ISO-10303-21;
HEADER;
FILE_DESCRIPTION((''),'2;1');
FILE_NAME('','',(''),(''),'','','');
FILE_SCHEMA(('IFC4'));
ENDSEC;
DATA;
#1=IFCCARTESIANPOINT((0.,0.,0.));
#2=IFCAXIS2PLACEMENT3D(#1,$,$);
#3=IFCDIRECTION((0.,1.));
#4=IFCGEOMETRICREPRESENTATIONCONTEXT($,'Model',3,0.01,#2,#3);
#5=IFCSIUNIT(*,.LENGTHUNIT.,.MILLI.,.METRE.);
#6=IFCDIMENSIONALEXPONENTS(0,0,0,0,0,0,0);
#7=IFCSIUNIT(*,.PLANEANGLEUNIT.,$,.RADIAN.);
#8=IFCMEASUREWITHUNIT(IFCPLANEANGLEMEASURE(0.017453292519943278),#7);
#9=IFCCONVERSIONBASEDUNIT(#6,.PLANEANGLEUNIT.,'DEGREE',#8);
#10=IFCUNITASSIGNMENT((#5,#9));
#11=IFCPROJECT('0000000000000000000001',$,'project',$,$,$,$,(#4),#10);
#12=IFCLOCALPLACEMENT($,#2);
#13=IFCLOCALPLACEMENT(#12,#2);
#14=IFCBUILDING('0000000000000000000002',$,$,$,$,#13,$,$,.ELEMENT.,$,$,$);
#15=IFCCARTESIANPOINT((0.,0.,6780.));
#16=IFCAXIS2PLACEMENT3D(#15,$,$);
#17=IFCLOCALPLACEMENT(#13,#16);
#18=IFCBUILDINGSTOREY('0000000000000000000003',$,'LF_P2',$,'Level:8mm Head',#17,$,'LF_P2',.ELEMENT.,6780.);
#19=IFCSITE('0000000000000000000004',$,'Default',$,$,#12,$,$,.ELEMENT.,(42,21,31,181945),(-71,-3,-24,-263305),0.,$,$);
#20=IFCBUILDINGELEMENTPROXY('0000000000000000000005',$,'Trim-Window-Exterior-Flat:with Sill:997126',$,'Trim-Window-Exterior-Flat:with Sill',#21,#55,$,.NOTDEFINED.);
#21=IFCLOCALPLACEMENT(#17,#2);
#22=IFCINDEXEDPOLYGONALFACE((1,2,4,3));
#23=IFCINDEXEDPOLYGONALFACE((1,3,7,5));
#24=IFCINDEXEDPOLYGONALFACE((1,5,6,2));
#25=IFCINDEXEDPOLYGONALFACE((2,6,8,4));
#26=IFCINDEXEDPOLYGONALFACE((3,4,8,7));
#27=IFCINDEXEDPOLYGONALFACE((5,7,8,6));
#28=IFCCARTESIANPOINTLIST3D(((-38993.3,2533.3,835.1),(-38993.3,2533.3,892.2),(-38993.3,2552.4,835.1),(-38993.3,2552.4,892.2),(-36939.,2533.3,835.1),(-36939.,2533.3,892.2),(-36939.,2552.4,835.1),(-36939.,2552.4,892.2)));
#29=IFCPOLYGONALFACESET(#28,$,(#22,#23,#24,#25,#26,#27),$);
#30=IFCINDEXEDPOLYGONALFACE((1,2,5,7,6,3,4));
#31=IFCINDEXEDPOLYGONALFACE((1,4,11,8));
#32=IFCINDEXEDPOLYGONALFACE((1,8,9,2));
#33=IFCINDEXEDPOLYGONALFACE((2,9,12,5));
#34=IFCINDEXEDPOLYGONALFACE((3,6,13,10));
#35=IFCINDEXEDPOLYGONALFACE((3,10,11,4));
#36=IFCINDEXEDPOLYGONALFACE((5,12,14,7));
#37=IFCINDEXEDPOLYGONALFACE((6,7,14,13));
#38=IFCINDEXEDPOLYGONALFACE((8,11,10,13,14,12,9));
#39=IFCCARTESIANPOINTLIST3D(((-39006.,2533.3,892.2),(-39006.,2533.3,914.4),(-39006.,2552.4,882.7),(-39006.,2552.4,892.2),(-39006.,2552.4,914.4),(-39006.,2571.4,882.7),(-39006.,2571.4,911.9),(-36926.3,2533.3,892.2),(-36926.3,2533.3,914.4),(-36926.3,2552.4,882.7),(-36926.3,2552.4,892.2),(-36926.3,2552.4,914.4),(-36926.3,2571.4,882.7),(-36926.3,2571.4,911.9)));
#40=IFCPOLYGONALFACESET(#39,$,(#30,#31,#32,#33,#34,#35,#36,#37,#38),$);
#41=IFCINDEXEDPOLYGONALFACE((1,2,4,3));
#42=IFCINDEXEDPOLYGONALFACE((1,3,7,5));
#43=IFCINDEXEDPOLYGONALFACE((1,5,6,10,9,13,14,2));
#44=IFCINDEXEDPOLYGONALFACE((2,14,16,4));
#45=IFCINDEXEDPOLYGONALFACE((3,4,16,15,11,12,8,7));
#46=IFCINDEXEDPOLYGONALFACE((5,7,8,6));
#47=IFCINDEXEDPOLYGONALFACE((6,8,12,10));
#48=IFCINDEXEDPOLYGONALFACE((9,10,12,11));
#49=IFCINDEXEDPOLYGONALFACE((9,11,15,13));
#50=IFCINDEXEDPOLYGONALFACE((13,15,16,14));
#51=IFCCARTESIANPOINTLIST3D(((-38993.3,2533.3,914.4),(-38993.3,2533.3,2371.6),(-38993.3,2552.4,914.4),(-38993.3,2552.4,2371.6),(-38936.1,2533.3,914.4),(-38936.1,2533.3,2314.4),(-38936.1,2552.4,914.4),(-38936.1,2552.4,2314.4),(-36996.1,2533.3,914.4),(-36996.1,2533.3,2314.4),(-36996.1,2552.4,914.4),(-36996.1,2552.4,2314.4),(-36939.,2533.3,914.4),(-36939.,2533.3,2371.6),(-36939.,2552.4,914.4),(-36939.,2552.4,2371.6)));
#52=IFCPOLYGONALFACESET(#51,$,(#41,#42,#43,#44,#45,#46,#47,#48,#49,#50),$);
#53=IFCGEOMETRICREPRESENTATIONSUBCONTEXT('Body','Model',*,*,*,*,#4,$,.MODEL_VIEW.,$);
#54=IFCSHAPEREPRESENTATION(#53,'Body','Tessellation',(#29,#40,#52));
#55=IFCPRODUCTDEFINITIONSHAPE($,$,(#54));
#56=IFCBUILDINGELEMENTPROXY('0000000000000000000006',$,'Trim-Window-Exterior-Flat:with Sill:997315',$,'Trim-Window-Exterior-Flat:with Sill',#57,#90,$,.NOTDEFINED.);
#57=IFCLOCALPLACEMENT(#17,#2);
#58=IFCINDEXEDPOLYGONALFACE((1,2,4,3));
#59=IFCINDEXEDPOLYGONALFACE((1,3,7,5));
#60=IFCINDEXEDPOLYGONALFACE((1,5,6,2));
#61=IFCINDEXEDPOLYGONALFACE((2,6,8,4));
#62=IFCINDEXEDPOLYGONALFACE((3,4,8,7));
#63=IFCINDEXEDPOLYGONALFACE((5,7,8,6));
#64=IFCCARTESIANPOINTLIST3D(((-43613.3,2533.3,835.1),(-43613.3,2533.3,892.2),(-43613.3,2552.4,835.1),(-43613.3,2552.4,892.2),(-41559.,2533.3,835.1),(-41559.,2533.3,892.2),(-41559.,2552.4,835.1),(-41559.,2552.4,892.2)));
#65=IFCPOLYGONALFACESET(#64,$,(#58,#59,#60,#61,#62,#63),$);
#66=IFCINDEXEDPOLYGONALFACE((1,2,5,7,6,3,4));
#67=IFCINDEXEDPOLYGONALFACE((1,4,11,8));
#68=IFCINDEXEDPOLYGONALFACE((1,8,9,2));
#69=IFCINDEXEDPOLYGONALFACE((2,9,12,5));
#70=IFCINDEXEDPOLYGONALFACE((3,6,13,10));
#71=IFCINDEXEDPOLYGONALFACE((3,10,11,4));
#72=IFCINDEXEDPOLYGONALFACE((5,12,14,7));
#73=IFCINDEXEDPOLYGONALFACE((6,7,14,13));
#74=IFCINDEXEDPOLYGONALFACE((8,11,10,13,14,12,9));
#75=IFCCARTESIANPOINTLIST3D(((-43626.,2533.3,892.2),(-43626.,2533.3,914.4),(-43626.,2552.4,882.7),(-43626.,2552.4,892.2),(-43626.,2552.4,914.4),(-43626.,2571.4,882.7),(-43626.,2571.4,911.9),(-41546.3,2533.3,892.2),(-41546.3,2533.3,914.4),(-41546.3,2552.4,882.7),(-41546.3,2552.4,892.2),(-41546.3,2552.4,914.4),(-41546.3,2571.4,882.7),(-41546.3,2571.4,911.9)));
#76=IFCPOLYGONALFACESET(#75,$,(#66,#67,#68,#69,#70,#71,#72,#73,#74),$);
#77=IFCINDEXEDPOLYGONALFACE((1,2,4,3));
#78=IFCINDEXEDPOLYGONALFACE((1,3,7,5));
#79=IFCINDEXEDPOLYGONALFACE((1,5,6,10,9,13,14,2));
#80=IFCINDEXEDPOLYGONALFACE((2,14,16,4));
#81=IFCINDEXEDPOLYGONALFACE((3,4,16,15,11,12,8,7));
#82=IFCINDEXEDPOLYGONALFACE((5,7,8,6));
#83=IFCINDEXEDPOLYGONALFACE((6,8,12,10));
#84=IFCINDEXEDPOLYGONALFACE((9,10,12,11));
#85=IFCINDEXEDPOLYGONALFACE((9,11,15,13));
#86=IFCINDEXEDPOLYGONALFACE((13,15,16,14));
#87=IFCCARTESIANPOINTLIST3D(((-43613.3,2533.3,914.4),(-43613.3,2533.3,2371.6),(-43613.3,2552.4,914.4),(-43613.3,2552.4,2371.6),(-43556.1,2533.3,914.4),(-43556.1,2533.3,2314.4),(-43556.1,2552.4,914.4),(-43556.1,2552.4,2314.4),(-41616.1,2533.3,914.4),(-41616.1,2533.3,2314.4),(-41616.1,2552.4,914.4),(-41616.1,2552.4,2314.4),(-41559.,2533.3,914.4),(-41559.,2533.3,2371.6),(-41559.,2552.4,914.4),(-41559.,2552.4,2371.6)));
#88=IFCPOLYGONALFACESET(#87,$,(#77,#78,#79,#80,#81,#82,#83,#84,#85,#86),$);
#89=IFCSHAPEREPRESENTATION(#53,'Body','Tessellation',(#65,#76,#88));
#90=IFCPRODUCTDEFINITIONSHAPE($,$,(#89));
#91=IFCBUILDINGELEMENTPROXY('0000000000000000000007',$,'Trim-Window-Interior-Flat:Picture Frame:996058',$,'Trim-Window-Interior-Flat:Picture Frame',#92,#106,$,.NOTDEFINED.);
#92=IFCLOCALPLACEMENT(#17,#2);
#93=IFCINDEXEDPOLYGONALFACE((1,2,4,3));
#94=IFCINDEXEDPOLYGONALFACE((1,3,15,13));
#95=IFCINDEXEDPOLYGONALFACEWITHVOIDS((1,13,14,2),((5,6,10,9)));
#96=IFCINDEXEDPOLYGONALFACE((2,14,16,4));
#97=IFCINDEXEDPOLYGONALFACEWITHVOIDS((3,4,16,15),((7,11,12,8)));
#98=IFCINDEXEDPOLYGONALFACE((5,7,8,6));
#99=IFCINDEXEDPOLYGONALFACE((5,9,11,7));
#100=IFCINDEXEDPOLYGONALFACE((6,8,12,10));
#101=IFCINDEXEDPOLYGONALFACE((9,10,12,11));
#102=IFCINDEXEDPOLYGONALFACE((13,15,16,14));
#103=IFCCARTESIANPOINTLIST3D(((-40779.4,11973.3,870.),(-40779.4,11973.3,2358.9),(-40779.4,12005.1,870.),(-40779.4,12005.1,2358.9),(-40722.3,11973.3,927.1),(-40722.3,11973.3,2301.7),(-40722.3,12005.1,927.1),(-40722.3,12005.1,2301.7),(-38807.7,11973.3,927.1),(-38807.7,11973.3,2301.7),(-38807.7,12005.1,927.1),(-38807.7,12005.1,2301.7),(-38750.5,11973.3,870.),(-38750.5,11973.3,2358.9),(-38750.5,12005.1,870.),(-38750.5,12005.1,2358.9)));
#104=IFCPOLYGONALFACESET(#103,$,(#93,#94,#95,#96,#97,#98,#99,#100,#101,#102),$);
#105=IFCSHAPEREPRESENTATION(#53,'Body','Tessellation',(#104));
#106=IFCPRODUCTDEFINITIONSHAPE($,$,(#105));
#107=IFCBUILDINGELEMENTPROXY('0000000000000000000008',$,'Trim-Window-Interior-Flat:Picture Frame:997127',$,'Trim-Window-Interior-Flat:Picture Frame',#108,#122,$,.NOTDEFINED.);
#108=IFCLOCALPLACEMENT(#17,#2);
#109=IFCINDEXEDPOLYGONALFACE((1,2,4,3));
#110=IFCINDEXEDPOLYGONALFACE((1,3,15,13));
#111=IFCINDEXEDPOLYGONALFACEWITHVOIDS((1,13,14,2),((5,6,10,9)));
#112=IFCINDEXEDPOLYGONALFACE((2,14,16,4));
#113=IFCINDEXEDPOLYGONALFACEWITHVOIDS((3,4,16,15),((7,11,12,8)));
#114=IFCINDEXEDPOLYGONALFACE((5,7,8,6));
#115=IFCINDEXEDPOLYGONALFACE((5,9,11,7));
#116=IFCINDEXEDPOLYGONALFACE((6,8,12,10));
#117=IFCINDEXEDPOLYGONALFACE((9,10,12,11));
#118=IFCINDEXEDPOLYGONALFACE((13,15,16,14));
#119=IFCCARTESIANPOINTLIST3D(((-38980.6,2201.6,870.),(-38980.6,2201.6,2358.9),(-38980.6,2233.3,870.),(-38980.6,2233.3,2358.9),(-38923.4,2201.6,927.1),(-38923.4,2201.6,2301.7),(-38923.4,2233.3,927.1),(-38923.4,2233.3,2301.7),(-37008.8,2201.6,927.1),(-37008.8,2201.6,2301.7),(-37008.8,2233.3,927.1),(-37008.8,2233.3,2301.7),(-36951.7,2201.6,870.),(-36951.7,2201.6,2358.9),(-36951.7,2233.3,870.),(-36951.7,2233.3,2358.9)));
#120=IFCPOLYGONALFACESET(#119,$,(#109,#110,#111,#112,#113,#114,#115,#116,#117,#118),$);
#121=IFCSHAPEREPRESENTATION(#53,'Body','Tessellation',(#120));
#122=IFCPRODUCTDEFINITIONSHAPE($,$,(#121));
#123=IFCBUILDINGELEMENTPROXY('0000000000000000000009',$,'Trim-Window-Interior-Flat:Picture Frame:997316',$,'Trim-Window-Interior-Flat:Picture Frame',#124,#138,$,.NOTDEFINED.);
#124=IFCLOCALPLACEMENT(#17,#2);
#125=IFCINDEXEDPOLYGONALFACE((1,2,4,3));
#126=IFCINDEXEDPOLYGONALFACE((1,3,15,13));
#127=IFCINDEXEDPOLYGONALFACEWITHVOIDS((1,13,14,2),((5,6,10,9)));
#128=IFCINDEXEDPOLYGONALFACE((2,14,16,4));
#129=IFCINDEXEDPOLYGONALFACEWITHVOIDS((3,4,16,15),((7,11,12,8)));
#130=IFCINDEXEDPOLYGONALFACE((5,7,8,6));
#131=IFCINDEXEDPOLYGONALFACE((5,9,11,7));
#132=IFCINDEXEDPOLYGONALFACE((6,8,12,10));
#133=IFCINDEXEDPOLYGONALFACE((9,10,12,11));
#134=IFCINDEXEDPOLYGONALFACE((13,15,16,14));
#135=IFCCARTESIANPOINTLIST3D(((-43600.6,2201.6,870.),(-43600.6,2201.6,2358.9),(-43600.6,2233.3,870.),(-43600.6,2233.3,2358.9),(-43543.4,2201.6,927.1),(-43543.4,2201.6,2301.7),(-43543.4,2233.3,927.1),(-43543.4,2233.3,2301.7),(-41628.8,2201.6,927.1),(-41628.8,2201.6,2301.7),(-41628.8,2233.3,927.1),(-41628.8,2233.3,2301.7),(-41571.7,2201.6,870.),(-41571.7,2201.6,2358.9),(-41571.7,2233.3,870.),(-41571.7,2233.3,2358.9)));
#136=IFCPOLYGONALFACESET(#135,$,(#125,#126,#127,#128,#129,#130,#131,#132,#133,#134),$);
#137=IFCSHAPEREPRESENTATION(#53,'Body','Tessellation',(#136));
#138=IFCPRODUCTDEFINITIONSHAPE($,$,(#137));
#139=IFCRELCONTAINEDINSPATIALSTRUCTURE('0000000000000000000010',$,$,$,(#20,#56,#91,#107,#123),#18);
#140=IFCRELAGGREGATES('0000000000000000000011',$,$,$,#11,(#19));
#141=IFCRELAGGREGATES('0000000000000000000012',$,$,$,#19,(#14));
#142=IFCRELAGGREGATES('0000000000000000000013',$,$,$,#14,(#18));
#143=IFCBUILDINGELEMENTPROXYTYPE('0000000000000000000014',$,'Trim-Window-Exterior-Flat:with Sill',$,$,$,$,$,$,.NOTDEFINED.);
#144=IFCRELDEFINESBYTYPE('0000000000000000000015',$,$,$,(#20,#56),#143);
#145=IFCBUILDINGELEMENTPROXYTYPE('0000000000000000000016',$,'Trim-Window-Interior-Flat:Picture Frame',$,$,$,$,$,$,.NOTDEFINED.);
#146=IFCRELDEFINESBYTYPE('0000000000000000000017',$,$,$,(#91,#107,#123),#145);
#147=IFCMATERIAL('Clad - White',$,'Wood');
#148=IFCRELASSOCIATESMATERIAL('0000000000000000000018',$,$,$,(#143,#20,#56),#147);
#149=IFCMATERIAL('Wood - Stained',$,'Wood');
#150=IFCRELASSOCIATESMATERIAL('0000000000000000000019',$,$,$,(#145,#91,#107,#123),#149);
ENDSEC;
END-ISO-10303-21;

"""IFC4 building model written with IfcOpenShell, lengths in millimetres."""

from ifc_helpers import new_model, entity, si_unit, converted_unit, direction, frame, origin, place, context, subcontext, project, spatial, indexed_curve, outline, extrude, source, transform, mapped, material, type_object, type_shapes, element, save


model = new_model("IFC4")

# Units and contexts
model_context = context("Model", 3, precision=0.01, world=origin(), true_north=direction((0.0, 1.0)))
body_context = subcontext(model_context, "Body", "Model", "MODEL_VIEW")
ifc_project = project(units=[si_unit("LENGTHUNIT", "METRE", prefix="MILLI"), converted_unit("PLANEANGLEUNIT", "DEGREE", entity("IfcPlaneAngleMeasure", 0.017453292519943278), si_unit("PLANEANGLEUNIT", "RADIAN"), dimensions=[0, 0, 0, 0, 0, 0, 0])], contexts=[model_context])

# Site, building, storey
site_placement = place(None, origin())
site = spatial("IfcSite", under=ifc_project, at=site_placement, Name="Default", CompositionType="ELEMENT", RefLatitude=(42, 21, 31, 181945), RefLongitude=(-71, -3, -24, -263305), RefElevation=0.0)
building_placement = place(site_placement, origin())
building = spatial("IfcBuilding", under=site, at=building_placement, CompositionType="ELEMENT")
storey_placement = place(building_placement, frame((0.0, 0.0, 6780.0)))
storey = spatial("IfcBuildingStorey", under=building, at=storey_placement, Name="LF_P2", ObjectType="Level:8mm Head", LongName="LF_P2", CompositionType="ELEMENT", Elevation=6780.0)

# Building element proxies
ifc_material_1 = material(Name="Clad - White", Category="Wood")
ifc_material_2 = material(Name="Wood - Stained", Category="Wood")
building_element_proxy_type_1 = type_object("IfcBuildingElementProxyType", Name="Trim-Window-Exterior-Flat:with Sill", PredefinedType="NOTDEFINED", material=ifc_material_1)
shared_shape_1 = source(origin(), body_context, "Body", "SweptSolid", [
    extrude(outline(indexed_curve([(-1027.1, -28.6), (1027.1, -28.6), (1027.1, 28.6), (-1027.1, 28.6), (-1027.1, -28.6)], self_intersect=False)), frame((0.0, -1450.8, 0.0), z_axis=(0.0, 0.0, 1.0), x_axis=(-1.0, 0.0, 0.0)), (0.0, 0.0, 1.0), 19.0),
    extrude(outline(indexed_curve([(-19.0, -16.0), (0.0, -16.0), (0.0, -6.4), (19.0, -6.4), (19.0, 15.8), (0.0, 15.8), (-19.0, 13.3), (-19.0, -16.0)], self_intersect=False)), frame((-1039.8, -1415.8, 19.0), z_axis=(1.0, 0.0, 0.0), x_axis=(0.0, 0.0, -1.0)), (0.0, 0.0, 1.0), 2079.7),
    extrude(outline(indexed_curve([(-742.9, -1027.1), (714.3, -1027.1), (714.3, -970.0), (-685.7, -970.0), (-685.7, 970.0), (714.3, 970.0), (714.3, 1027.1), (-742.9, 1027.1), (-742.9, -1027.1)], self_intersect=False)), frame((0.0, -685.7, 0.0), z_axis=(0.0, 0.0, 1.0), x_axis=(0.0, -1.0, 0.0)), (0.0, 0.0, 1.0), 19.0),
])
type_shapes(building_element_proxy_type_1, [shared_shape_1])
for number, where, z_axis, x_axis, name in (
    (1, (-37966.1, 2533.3, 2314.4), (0.0, 1.0, 0.0), (-1.0, 0.0, 0.0), "Trim-Window-Exterior-Flat:with Sill:997126"),
    (2, (-42586.1, 2533.3, 2314.4), (0.0, 1.0, 0.0), (-1.0, 0.0, 0.0), "Trim-Window-Exterior-Flat:with Sill:997315"),
):
    element("IfcBuildingElementProxy", number, at=place(storey_placement, frame(where, z_axis=z_axis, x_axis=x_axis)), inside=storey, type_object=building_element_proxy_type_1, material=ifc_material_1, Name=name, ObjectType="Trim-Window-Exterior-Flat:with Sill", PredefinedType="NOTDEFINED", context=body_context, shape_type="MappedRepresentation", body=[
        mapped(shared_shape_1, transform((0.0, 0.0, 0.0), scale=1.0)),
    ])
building_element_proxy_type_2 = type_object("IfcBuildingElementProxyType", Name="Trim-Window-Interior-Flat:Picture Frame", PredefinedType="NOTDEFINED", material=ifc_material_2)
shared_shape_2 = source(origin(), body_context, "Body", "SweptSolid", [
    extrude(outline(indexed_curve([(-1014.4, -744.4), (1014.4, -744.4), (1014.4, 744.4), (-1014.4, 744.4), (-1014.4, -744.4)], self_intersect=False), holes=[indexed_curve([(-957.3, -687.3), (-957.3, 687.3), (957.3, 687.3), (957.3, -687.3), (-957.3, -687.3)], self_intersect=False)]), frame((0.0, -700.0, 0.0), z_axis=(0.0, 0.0, 1.0), x_axis=(-1.0, 0.0, 0.0)), (0.0, 0.0, 1.0), 31.7),
])
type_shapes(building_element_proxy_type_2, [shared_shape_2])
for number, where, z_axis, x_axis, name in (
    (3, (-39765.0, 11973.3, 2314.4), (0.0, 1.0, 0.0), (-1.0, 0.0, 0.0), "Trim-Window-Interior-Flat:Picture Frame:996058"),
    (4, (-37966.1, 2233.3, 2314.4), (0.0, -1.0, 0.0), (1.0, 0.0, 0.0), "Trim-Window-Interior-Flat:Picture Frame:997127"),
    (5, (-42586.1, 2233.3, 2314.4), (0.0, -1.0, 0.0), (1.0, 0.0, 0.0), "Trim-Window-Interior-Flat:Picture Frame:997316"),
):
    element("IfcBuildingElementProxy", number, at=place(storey_placement, frame(where, z_axis=z_axis, x_axis=x_axis)), inside=storey, type_object=building_element_proxy_type_2, material=ifc_material_2, Name=name, ObjectType="Trim-Window-Interior-Flat:Picture Frame", PredefinedType="NOTDEFINED", context=body_context, shape_type="MappedRepresentation", body=[
        mapped(shared_shape_2, transform((0.0, 0.0, 0.0), scale=1.0)),
    ])

save(model, "model.ifc")
